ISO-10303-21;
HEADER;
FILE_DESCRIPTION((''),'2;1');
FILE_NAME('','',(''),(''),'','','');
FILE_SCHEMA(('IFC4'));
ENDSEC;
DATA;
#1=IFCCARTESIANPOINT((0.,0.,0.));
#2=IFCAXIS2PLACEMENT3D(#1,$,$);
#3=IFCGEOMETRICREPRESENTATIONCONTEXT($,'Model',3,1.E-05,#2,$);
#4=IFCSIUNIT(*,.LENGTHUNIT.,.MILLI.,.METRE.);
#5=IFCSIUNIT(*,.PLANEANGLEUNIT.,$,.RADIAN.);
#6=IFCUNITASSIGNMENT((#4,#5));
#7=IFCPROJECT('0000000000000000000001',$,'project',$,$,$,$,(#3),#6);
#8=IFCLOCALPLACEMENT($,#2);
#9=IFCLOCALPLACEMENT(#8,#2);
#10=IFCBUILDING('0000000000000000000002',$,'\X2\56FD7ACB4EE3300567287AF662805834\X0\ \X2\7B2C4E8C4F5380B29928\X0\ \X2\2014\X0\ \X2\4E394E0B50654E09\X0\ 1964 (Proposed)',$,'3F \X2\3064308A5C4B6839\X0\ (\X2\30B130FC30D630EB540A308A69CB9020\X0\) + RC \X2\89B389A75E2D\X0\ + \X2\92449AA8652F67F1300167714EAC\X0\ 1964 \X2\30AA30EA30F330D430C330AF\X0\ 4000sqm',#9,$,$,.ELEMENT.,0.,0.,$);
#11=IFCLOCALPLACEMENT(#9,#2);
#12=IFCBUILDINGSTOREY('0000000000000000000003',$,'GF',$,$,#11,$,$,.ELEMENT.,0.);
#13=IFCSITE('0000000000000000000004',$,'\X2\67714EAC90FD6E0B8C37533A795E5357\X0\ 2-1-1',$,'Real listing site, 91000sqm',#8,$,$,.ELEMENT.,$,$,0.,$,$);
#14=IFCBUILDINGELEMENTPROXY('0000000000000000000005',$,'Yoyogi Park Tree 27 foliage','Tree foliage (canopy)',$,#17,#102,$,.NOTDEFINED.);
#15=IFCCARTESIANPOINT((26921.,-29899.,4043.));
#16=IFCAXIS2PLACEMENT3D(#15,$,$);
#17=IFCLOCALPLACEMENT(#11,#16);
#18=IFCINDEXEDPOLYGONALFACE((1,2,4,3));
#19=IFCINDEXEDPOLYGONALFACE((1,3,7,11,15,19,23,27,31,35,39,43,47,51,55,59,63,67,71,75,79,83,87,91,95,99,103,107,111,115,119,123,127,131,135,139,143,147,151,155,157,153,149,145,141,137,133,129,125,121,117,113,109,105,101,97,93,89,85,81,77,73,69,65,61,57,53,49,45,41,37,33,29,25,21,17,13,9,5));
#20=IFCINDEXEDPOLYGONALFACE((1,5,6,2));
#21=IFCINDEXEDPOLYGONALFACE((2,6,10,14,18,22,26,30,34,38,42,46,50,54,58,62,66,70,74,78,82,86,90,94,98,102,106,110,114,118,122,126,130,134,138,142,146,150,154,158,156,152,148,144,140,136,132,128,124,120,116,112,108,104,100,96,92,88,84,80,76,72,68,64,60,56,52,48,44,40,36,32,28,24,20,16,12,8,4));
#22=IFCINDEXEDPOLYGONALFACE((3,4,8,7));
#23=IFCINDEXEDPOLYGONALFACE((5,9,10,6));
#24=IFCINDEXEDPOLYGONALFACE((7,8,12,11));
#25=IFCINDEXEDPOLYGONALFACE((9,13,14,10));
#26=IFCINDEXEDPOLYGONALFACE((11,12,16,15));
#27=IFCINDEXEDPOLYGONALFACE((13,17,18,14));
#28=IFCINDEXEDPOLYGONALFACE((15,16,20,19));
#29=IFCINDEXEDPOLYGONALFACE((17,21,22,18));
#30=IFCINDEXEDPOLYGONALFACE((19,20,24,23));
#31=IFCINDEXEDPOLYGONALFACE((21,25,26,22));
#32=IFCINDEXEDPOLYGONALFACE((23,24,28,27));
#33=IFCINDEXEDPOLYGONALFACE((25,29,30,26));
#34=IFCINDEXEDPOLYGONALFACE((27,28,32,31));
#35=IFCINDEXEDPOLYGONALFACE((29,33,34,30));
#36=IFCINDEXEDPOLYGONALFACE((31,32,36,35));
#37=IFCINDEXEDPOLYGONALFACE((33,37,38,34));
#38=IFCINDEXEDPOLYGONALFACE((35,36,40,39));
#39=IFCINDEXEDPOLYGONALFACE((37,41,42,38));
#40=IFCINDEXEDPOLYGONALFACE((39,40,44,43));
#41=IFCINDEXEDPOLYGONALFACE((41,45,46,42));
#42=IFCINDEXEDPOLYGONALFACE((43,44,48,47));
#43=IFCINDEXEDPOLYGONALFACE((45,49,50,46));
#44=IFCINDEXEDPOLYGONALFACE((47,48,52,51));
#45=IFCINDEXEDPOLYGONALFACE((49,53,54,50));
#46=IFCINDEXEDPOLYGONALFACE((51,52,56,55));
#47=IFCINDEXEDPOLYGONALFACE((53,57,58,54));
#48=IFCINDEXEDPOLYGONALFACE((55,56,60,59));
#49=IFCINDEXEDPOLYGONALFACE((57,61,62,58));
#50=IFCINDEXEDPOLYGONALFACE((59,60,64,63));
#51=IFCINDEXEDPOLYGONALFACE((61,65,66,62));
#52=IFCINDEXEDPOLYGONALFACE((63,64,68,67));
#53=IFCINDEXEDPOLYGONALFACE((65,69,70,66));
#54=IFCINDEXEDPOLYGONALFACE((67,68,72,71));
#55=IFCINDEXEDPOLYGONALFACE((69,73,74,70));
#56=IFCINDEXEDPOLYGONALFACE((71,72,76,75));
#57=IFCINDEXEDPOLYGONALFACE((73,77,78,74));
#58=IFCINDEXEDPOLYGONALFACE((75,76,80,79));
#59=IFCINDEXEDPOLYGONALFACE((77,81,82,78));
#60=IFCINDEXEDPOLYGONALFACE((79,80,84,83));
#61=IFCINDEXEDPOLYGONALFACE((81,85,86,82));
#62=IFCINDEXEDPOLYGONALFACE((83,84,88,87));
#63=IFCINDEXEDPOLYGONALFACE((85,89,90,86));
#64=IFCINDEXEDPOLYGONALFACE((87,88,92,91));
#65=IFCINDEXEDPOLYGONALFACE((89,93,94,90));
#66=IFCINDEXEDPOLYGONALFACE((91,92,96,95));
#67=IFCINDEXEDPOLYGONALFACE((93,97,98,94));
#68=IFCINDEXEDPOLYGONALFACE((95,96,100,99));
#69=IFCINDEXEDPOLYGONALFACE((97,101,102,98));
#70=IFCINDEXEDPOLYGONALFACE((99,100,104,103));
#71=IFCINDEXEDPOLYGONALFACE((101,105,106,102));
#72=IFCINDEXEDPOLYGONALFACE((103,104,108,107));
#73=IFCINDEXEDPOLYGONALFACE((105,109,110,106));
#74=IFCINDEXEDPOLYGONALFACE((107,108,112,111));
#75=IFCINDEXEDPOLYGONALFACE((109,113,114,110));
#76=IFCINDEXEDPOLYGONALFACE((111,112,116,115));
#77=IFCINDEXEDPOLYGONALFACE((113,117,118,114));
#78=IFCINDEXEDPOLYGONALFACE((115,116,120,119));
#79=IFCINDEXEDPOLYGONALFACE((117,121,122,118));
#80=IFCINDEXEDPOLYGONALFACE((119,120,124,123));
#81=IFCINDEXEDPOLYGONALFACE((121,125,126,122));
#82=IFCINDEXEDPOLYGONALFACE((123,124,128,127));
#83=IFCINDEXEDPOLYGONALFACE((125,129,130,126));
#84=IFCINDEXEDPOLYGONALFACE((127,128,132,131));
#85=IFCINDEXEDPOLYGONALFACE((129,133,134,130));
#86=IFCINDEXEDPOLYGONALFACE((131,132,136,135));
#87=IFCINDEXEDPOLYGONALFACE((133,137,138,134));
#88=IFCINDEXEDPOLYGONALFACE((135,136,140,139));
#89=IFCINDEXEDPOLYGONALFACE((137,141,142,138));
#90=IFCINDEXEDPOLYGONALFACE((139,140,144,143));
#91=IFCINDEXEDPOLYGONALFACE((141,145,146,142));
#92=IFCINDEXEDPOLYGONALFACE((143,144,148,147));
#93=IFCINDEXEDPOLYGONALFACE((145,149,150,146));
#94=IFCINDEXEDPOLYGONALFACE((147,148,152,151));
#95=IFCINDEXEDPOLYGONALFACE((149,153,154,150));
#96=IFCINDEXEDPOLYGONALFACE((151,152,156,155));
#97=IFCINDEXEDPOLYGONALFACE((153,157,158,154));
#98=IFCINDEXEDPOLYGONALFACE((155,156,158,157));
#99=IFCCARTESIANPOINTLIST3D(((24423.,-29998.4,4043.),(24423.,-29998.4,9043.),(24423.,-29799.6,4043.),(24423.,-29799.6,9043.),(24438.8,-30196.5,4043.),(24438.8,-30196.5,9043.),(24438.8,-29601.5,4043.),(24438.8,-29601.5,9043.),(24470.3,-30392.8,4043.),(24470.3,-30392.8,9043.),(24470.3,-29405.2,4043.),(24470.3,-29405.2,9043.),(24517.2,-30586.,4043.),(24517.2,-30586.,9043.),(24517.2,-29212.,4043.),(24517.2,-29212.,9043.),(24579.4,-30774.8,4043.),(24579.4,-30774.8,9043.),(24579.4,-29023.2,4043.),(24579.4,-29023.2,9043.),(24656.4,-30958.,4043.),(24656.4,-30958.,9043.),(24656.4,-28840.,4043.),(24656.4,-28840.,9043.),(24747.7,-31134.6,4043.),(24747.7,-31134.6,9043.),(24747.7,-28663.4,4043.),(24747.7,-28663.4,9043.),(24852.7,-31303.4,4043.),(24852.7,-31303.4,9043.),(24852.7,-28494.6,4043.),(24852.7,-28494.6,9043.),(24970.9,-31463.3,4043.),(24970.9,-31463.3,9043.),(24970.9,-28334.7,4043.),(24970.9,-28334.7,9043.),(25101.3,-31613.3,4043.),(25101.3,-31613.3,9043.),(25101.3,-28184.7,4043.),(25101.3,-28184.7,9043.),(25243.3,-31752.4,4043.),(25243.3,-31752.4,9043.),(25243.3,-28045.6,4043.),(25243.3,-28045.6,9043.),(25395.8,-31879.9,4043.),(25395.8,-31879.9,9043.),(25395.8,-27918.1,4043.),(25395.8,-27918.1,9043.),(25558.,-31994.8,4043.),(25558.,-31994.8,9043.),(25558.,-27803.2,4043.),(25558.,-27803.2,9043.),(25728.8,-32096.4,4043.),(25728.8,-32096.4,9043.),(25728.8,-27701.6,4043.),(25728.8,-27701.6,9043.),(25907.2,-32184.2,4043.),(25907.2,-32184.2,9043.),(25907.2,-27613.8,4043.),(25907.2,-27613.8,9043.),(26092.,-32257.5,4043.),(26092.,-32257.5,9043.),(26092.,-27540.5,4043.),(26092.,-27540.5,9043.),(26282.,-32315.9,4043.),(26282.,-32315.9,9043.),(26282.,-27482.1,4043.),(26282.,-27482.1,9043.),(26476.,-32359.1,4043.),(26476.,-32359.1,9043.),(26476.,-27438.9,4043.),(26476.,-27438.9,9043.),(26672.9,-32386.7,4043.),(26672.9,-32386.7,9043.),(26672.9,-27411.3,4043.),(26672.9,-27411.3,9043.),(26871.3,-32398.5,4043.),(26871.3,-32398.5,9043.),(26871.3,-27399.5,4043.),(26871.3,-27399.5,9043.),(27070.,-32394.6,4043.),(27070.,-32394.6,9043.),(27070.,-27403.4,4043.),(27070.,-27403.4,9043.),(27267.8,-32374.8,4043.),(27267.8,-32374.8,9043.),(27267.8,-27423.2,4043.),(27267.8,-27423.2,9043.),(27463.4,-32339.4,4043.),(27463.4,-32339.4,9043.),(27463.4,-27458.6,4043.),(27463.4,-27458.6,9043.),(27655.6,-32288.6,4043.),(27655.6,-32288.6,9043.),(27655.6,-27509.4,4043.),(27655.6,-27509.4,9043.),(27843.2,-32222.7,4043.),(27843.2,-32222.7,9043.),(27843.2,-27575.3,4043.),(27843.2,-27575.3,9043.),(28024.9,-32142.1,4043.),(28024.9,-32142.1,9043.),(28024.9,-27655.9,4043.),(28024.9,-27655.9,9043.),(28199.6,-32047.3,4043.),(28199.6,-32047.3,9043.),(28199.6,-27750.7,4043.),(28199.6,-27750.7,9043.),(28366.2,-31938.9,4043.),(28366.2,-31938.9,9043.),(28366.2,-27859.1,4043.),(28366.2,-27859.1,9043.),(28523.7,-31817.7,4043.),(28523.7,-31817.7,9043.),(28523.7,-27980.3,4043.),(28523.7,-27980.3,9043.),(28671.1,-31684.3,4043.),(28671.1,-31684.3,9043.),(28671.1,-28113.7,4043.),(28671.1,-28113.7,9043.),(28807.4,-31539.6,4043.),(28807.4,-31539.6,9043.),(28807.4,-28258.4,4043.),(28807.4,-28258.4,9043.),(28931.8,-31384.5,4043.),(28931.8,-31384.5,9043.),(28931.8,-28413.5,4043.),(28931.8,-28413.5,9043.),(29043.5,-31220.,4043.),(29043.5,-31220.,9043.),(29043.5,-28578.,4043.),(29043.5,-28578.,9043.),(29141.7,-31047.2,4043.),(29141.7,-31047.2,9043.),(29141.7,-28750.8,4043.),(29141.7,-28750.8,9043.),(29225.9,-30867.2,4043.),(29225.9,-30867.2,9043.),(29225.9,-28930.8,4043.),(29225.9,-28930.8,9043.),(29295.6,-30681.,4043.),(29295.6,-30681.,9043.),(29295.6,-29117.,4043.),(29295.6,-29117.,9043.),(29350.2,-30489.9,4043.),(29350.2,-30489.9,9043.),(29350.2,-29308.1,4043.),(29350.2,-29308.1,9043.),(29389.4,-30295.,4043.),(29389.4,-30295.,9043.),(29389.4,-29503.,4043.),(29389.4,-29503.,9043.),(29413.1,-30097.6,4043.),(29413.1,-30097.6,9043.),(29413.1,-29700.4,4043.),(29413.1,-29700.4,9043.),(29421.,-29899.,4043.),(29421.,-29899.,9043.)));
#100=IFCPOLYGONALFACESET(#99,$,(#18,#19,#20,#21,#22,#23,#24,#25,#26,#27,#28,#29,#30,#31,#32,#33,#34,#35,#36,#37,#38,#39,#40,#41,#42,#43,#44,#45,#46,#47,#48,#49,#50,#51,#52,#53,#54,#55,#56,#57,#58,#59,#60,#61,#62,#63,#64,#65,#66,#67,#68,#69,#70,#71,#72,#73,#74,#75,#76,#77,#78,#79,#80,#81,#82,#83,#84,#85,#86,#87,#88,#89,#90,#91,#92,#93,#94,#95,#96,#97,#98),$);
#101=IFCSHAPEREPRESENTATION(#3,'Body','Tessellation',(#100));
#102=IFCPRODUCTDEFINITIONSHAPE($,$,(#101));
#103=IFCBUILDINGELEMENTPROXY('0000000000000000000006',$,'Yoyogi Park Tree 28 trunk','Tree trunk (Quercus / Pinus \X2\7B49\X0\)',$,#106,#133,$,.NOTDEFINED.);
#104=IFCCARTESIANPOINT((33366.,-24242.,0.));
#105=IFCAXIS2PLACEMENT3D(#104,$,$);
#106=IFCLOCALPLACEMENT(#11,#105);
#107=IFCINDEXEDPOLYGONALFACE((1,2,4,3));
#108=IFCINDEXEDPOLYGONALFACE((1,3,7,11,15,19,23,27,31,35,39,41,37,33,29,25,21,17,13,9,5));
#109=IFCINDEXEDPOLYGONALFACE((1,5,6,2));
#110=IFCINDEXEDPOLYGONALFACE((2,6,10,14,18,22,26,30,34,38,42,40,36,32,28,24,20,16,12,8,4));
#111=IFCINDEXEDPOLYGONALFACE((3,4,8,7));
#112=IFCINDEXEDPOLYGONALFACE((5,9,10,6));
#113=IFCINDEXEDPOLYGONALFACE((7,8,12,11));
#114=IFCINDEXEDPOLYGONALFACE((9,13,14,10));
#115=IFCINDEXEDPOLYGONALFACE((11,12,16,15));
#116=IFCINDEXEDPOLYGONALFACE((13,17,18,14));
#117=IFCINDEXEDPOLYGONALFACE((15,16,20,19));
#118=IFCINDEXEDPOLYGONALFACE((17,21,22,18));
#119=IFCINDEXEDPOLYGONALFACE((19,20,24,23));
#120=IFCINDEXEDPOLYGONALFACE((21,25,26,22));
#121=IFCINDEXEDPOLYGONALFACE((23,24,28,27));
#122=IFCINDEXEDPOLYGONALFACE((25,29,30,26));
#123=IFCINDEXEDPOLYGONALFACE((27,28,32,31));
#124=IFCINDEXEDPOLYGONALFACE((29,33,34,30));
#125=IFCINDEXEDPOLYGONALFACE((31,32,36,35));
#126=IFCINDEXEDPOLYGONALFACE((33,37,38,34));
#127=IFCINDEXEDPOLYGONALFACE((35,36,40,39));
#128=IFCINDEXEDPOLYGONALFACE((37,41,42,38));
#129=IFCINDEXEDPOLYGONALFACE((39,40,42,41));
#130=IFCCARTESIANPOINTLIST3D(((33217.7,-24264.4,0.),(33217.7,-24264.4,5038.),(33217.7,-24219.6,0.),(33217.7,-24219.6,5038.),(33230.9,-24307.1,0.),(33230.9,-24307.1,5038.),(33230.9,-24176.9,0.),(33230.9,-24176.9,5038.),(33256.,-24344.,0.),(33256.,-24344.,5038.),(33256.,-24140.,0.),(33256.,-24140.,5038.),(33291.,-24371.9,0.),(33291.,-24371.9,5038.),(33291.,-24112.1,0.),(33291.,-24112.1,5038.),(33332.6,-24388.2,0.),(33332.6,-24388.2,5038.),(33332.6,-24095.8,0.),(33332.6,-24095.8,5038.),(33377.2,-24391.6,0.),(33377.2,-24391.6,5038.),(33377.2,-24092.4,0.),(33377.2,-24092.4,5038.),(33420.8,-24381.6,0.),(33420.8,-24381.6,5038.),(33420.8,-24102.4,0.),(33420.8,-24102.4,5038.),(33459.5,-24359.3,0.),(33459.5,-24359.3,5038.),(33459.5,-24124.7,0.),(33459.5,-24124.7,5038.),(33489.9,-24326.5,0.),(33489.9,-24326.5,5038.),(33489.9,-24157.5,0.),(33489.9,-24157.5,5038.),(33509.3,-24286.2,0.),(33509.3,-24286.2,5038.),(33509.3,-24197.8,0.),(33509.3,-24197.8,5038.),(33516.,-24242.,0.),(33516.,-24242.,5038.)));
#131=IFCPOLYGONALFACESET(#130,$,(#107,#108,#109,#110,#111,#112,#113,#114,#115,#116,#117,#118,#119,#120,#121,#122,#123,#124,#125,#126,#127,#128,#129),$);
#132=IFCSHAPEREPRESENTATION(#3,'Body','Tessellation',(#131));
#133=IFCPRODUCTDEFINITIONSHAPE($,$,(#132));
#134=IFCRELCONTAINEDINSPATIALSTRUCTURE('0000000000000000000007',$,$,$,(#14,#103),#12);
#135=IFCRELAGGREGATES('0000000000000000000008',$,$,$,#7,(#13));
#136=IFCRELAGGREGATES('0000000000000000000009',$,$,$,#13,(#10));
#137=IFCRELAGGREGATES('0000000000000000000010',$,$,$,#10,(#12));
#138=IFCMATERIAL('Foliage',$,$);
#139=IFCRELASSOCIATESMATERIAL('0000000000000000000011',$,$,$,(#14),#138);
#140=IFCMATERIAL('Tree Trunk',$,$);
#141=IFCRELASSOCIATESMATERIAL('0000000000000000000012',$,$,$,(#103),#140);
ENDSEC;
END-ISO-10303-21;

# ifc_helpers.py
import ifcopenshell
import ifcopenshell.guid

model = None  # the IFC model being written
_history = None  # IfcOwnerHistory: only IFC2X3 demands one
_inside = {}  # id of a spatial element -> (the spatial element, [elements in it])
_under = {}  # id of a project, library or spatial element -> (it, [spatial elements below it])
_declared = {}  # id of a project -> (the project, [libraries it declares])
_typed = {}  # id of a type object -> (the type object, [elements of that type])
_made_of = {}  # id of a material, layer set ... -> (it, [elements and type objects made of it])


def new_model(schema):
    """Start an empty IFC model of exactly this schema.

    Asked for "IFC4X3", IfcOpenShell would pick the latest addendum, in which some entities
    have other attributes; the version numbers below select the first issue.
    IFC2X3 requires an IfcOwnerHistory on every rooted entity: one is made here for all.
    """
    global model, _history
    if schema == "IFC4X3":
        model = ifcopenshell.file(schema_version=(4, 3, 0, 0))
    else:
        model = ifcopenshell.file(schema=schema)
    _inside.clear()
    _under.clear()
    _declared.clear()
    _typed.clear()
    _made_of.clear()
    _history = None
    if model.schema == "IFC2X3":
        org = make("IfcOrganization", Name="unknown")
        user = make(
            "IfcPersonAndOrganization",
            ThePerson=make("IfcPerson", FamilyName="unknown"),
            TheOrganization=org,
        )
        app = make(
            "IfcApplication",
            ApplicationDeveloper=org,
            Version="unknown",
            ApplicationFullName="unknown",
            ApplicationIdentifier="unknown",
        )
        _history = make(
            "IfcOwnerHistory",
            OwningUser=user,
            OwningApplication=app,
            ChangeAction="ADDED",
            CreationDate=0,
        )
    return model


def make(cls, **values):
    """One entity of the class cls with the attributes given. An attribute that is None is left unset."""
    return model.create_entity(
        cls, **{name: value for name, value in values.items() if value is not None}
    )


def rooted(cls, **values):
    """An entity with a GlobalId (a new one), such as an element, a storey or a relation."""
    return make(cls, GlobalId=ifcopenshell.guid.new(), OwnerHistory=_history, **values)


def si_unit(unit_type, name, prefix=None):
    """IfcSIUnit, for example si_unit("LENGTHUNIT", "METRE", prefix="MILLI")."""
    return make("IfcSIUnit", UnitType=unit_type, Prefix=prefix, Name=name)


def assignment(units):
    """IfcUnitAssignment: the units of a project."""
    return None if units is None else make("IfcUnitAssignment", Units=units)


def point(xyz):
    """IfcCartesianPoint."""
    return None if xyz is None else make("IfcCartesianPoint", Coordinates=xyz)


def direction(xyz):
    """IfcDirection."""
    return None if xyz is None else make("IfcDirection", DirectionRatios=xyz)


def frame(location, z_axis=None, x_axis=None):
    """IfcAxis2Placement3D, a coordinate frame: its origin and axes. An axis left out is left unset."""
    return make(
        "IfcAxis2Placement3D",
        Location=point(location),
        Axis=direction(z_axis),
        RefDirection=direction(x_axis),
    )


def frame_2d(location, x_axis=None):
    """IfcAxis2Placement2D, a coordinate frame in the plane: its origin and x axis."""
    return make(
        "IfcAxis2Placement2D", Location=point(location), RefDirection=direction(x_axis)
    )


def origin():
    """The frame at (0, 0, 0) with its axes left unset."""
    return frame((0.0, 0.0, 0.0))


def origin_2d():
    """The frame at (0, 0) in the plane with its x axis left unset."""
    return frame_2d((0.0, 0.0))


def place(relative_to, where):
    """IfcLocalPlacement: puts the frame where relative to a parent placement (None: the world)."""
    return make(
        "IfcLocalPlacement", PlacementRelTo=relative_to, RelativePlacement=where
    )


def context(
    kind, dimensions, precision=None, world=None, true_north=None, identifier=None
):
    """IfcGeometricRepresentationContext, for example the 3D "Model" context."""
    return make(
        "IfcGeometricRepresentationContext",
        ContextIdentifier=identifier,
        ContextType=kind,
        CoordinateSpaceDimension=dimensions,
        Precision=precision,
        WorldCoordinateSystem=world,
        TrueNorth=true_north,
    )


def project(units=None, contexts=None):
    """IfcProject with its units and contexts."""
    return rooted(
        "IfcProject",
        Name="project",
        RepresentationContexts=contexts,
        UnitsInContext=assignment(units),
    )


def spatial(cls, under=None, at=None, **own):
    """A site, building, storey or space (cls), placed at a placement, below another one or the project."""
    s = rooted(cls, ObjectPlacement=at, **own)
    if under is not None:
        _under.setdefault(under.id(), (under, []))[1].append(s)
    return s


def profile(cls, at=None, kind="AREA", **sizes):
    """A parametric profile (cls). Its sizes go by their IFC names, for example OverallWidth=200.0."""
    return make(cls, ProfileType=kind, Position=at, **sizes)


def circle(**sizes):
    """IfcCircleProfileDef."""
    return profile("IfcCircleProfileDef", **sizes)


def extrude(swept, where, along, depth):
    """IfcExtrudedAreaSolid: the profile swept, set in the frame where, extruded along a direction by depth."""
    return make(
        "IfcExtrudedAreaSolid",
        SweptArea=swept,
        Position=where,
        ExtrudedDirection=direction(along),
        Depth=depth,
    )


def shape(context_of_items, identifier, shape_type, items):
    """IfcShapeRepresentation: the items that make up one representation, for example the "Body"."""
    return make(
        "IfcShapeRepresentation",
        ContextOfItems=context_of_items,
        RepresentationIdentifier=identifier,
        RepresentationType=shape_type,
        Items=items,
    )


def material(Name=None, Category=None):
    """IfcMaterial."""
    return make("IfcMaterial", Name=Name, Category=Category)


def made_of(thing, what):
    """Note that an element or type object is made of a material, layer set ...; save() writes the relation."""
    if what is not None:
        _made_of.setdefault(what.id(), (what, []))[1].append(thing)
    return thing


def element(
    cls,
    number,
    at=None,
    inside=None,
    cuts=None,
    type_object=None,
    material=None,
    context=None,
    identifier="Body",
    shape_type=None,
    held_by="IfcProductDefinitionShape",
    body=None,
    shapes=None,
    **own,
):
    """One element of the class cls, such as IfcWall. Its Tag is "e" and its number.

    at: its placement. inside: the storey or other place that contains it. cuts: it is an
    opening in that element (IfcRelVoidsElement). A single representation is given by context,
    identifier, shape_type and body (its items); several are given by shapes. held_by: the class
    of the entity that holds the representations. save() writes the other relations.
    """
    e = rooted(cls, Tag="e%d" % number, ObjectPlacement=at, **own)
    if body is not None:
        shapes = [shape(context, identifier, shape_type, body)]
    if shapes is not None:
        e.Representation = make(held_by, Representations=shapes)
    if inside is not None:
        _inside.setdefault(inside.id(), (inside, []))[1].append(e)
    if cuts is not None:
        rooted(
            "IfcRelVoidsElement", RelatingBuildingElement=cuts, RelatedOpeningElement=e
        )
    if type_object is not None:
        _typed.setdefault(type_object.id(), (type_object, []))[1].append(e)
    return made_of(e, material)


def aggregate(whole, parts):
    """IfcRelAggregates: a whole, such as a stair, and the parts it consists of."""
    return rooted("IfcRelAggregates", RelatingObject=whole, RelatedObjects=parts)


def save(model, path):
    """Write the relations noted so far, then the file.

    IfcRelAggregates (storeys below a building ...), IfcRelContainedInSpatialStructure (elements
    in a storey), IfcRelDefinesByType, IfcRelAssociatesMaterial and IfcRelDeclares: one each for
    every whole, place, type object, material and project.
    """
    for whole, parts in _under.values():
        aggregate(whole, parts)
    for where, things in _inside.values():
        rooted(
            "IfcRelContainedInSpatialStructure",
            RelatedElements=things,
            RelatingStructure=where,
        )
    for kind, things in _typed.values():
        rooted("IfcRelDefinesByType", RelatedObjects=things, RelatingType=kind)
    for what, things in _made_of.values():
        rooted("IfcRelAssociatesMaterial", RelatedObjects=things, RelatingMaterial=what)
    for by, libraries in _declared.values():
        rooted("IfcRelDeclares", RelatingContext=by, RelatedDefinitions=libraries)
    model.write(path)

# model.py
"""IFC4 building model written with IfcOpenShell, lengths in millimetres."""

from ifc_helpers import new_model, si_unit, frame, origin, origin_2d, place, context, project, spatial, circle, extrude, material, element, save


model = new_model("IFC4")

# Units and contexts
model_context = context("Model", 3, precision=1e-05, world=origin())
ifc_project = project(units=[si_unit("LENGTHUNIT", "METRE", prefix="MILLI"), si_unit("PLANEANGLEUNIT", "RADIAN")], contexts=[model_context])

# Site, building, storey
site_placement = place(None, origin())
site = spatial("IfcSite", under=ifc_project, at=site_placement, Name="東京都渋谷区神南 2-1-1", ObjectType="Real listing site, 91000sqm", CompositionType="ELEMENT", RefElevation=0.0)
building_placement = place(site_placement, origin())
building = spatial("IfcBuilding", under=site, at=building_placement, Name="国立代々木競技場 第二体育館 — 丹下健三 1964 (Proposed)", ObjectType="3F つり屋根 (ケーブル吊り構造) + RC 観覧席 + 鉄骨支柱、東京 1964 オリンピック 4000sqm", CompositionType="ELEMENT", ElevationOfRefHeight=0.0, ElevationOfTerrain=0.0)
storey_placement = place(building_placement, origin())
storey = spatial("IfcBuildingStorey", under=building, at=storey_placement, Name="GF", CompositionType="ELEMENT", Elevation=0.0)

# Building element proxies
ifc_material_1 = material(Name="Tree Trunk")
ifc_material_2 = material(Name="Foliage")
proxy_1_placement = place(storey_placement, frame((26921.0, -29899.0, 4043.0)))
element("IfcBuildingElementProxy", 1, at=proxy_1_placement, inside=storey, material=ifc_material_2, Name="Yoyogi Park Tree 27 foliage", Description="Tree foliage (canopy)", PredefinedType="NOTDEFINED", context=model_context, shape_type="SweptSolid", body=[
    extrude(circle(Radius=2500.0, at=origin_2d()), frame((26921.0, -29899.0, 4043.0)), (0.0, 0.0, 1.0), 5000.0),
])
proxy_2_placement = place(storey_placement, frame((33366.0, -24242.0, 0.0)))
element("IfcBuildingElementProxy", 2, at=proxy_2_placement, inside=storey, material=ifc_material_1, Name="Yoyogi Park Tree 28 trunk", Description="Tree trunk (Quercus / Pinus 等)", PredefinedType="NOTDEFINED", context=model_context, shape_type="SweptSolid", body=[
    extrude(circle(Radius=150.0, at=origin_2d()), frame((33366.0, -24242.0, 0.0)), (0.0, 0.0, 1.0), 5038.0),
])

save(model, "model.ifc")
